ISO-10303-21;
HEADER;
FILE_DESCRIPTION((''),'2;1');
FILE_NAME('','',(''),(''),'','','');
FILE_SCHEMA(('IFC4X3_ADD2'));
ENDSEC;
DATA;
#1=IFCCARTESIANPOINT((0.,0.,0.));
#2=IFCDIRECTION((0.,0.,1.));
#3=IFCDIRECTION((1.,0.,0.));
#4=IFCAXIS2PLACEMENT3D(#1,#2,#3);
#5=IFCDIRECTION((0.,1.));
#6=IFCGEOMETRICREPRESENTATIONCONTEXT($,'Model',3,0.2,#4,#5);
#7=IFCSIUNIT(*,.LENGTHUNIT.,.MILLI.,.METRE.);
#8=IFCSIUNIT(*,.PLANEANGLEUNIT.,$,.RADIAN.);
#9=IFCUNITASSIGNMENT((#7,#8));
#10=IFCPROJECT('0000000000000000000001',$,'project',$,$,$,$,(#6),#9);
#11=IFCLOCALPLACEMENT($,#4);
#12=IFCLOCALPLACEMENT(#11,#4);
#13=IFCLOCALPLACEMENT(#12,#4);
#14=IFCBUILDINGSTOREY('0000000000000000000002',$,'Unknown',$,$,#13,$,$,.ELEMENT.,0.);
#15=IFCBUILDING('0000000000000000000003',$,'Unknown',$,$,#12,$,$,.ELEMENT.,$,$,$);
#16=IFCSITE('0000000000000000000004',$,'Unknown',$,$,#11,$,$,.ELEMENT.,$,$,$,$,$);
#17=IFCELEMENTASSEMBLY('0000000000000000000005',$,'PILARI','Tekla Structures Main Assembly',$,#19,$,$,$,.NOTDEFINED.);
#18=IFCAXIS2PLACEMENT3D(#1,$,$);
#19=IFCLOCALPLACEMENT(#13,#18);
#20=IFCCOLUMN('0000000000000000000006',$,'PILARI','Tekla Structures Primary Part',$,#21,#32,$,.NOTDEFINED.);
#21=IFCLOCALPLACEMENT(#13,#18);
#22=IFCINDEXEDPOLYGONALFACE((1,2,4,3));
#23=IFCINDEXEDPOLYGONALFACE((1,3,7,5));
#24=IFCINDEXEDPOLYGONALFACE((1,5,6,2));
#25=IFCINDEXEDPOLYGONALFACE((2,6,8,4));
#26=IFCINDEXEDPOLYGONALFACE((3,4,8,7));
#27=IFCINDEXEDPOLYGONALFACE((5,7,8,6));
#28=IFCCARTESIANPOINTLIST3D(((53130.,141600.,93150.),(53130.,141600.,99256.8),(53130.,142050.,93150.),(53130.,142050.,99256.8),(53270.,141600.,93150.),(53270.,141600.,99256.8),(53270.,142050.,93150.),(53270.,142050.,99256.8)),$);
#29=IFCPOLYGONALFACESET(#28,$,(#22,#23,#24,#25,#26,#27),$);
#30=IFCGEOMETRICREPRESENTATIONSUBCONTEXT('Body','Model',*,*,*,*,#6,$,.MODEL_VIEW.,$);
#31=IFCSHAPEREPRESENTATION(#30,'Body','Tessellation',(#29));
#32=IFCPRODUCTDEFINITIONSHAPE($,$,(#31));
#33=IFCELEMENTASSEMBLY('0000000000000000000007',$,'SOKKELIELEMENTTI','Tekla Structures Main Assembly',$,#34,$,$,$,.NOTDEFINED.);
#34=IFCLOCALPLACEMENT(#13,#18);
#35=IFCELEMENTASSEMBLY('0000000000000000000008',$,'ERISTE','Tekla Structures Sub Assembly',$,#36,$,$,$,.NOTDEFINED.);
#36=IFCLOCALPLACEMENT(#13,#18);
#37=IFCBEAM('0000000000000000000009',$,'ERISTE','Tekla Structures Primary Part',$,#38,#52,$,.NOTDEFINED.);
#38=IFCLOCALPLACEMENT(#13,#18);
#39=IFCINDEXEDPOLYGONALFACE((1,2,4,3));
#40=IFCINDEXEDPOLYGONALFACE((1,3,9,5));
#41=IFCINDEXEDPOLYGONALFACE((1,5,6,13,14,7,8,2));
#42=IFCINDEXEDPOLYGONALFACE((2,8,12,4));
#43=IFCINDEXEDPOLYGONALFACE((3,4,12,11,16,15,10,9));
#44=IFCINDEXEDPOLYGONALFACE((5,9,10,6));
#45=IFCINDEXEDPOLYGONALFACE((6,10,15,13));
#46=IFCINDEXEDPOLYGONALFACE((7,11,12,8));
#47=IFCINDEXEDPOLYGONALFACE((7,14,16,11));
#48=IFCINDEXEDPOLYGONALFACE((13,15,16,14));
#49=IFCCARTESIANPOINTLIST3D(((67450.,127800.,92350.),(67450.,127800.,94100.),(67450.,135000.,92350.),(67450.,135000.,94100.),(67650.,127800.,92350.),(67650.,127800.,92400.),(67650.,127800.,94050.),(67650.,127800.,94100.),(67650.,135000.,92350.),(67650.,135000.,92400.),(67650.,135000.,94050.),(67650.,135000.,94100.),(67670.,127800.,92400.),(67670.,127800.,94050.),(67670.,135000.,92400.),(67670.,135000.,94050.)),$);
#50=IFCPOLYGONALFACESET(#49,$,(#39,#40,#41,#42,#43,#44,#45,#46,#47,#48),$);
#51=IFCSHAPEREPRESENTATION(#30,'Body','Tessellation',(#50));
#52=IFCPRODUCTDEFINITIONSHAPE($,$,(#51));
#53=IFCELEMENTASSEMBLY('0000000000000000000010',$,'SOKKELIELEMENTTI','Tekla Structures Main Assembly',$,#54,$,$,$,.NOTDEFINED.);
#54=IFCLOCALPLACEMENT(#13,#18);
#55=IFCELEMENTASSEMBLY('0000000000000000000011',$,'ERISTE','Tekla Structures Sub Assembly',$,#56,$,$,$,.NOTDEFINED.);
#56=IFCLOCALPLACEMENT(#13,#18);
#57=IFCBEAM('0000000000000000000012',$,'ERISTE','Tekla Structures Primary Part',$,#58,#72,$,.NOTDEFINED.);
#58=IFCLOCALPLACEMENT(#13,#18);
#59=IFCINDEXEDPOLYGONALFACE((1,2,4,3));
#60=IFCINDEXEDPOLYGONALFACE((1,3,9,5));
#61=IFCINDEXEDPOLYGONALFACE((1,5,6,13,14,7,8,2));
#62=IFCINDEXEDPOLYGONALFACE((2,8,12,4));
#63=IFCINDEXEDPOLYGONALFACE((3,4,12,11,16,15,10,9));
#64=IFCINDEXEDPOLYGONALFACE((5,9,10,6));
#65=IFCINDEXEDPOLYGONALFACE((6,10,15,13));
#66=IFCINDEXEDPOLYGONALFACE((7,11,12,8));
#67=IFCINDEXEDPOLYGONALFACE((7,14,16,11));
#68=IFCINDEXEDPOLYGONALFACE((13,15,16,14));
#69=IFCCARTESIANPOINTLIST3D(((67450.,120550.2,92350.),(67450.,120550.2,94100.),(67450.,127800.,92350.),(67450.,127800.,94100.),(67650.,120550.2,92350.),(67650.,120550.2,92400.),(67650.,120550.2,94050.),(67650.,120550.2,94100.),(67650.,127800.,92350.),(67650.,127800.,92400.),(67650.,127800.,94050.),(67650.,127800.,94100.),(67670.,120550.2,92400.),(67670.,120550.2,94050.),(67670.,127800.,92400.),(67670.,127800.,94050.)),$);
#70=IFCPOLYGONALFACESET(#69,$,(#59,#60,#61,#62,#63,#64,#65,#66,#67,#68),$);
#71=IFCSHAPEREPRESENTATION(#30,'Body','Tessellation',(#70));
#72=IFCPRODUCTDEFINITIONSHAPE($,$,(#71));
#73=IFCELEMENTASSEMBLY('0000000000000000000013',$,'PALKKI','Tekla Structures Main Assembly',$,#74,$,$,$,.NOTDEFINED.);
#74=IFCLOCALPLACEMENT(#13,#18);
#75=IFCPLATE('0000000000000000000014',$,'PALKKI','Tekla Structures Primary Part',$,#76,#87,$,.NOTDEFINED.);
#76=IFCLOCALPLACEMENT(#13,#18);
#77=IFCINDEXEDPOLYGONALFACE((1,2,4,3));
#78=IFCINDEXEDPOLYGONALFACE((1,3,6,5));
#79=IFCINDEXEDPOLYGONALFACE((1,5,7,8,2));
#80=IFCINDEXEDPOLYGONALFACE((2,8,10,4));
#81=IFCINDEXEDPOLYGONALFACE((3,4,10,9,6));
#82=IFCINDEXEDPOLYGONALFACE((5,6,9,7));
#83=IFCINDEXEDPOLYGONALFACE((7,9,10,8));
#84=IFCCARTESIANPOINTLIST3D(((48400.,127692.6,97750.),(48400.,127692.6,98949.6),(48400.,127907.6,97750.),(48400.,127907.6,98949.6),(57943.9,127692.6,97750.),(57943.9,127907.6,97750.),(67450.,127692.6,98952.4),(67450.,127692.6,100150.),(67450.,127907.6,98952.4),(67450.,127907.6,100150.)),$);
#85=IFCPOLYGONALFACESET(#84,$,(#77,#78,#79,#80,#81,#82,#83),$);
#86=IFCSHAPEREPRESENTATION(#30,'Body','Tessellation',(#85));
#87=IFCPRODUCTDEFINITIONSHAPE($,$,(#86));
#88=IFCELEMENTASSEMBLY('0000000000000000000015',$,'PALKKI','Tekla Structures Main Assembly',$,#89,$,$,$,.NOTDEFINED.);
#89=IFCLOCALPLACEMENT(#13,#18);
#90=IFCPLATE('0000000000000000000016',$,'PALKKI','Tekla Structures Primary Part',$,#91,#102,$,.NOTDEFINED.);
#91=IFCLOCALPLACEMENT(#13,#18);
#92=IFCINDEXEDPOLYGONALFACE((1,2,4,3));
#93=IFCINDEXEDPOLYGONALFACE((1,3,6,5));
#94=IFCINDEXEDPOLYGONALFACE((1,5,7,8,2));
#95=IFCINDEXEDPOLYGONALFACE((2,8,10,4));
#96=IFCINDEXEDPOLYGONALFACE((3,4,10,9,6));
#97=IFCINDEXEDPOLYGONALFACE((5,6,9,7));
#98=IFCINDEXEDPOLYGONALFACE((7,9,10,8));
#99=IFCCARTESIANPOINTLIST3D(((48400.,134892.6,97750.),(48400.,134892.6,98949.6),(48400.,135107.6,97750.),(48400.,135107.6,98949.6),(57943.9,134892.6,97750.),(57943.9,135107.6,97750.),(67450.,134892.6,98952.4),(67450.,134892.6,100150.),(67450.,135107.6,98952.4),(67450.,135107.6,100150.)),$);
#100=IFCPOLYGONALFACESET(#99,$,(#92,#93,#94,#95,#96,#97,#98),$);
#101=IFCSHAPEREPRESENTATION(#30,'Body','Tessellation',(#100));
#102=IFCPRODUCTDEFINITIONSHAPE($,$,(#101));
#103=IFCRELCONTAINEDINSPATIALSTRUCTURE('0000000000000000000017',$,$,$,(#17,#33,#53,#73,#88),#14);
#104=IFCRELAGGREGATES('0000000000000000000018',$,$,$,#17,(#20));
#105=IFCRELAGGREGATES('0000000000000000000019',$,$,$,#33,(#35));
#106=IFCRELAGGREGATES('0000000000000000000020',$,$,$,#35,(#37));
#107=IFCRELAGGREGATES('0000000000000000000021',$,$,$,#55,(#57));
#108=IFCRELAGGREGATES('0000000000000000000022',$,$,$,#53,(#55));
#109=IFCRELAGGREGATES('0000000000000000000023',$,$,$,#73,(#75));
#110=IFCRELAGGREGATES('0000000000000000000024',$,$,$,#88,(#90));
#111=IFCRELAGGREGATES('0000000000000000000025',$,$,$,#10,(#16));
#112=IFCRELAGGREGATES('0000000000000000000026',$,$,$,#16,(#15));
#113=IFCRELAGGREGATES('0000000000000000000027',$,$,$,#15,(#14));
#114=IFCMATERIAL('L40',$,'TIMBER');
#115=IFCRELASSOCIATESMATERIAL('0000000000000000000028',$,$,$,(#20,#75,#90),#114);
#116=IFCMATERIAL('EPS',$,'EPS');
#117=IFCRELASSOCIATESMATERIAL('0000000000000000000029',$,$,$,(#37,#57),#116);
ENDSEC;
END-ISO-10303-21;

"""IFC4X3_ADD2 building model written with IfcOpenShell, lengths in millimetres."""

from ifc_helpers import new_model, si_unit, direction, frame, origin_with_axes, place, context, subcontext, project, spatial, line, indexed_curve, outline, extrude, material, element, aggregate, save


model = new_model("IFC4X3_ADD2")

# Units and contexts
model_context = context("Model", 3, precision=0.2, world=origin_with_axes(), true_north=direction((0.0, 1.0)))
body_context = subcontext(model_context, "Body", "Model", "MODEL_VIEW")
ifc_project = project(units=[si_unit("LENGTHUNIT", "METRE", prefix="MILLI"), si_unit("PLANEANGLEUNIT", "RADIAN")], contexts=[model_context])

# Site, building, storey
site_placement = place(None, origin_with_axes())
site = spatial("IfcSite", under=ifc_project, at=site_placement, Name="Unknown", CompositionType="ELEMENT")
building_placement = place(site_placement, origin_with_axes())
building = spatial("IfcBuilding", under=site, at=building_placement, Name="Unknown", CompositionType="ELEMENT")
storey_placement = place(building_placement, origin_with_axes())
storey = spatial("IfcBuildingStorey", under=building, at=storey_placement, Name="Unknown", CompositionType="ELEMENT", Elevation=0.0)

# Element assembly, column
ifc_material_1 = material(Name="L40", Category="TIMBER")
assembly_1_placement = place(storey_placement, frame((53200.0, 141825.0, 93150.0), z_axis=(0.0, -1.0, 0.0), x_axis=(0.0, 0.0, 1.0)))
assembly_1 = element("IfcElementAssembly", 1, at=assembly_1_placement, inside=storey, Name="PILARI", Description="Tekla Structures Main Assembly", PredefinedType="NOTDEFINED")
column_1_placement = place(assembly_1_placement, origin_with_axes())
column_1 = element("IfcColumn", 2, at=column_1_placement, material=ifc_material_1, Name="PILARI", Description="Tekla Structures Primary Part", PredefinedType="NOTDEFINED", context=body_context, shape_type="SolidModel", body=[
    extrude(outline(indexed_curve([(-225.0, -70.0), (225.0, -70.0), (225.0, 70.0), (-225.0, 70.0)], segments=[line(1, 2, 3, 4, 1)])), frame((0.0, 0.0, 0.0), z_axis=(-1.0, 0.0, 0.0), x_axis=(0.0, 0.0, 1.0)), (0.0, 0.0, -1.0), 6106.8),
])
aggregate(assembly_1, [column_1])

# Element assemblies, beams, voiding features
assembly_2_placement = place(storey_placement, frame((67390.0, 135000.0, 93150.0), z_axis=(-1.0, 0.0, 0.0), x_axis=(0.0, -1.0, 0.0)))
assembly_2 = element("IfcElementAssembly", 3, at=assembly_2_placement, inside=storey, Name="SOKKELIELEMENTTI", Description="Tekla Structures Main Assembly", PredefinedType="NOTDEFINED")
assembly_3_placement = place(assembly_2_placement, frame((0.0, 75.0, -170.0), z_axis=(0.0, 0.0, 1.0), x_axis=(1.0, 0.0, 0.0)))
assembly_3 = element("IfcElementAssembly", 4, at=assembly_3_placement, Name="ERISTE", Description="Tekla Structures Sub Assembly", PredefinedType="NOTDEFINED")
aggregate(assembly_2, [assembly_3])
ifc_material_2 = material(Name="EPS", Category="EPS")
beam_1_placement = place(assembly_3_placement, origin_with_axes())
beam_1 = element("IfcBeam", 5, at=beam_1_placement, material=ifc_material_2, Name="ERISTE", Description="Tekla Structures Primary Part", PredefinedType="NOTDEFINED", context=body_context, shape_type="SolidModel", body=[
    extrude(outline(indexed_curve([(-110.0, -875.0), (110.0, -875.0), (110.0, 875.0), (-110.0, 875.0)], segments=[line(1, 2, 3, 4, 1)])), frame((0.0, 0.0, 0.0), z_axis=(-1.0, 0.0, 0.0), x_axis=(0.0, 0.0, 1.0)), (0.0, 0.0, -1.0), 7200.0),
])
voiding_feature_1_placement = place(beam_1_placement, frame((-1.0, 850.0, -100.0), z_axis=(0.0, 0.0, 1.0), x_axis=(1.0, 0.0, 0.0)))
element("IfcVoidingFeature", 6, at=voiding_feature_1_placement, cuts=beam_1, PredefinedType="HOLE", context=body_context, shape_type="SolidModel", body=[
    extrude(outline(indexed_curve([(-10.0, -25.0), (10.0, -25.0), (10.0, 25.0), (-10.0, 25.0)], segments=[line(1, 2, 3, 4, 1)])), frame((0.0, 0.0, 0.0), z_axis=(-1.0, 0.0, 0.0), x_axis=(0.0, 0.0, 1.0)), (0.0, 0.0, -1.0), 7202.0),
])
voiding_feature_2_placement = place(beam_1_placement, frame((-1.0, -850.0, -100.0), z_axis=(0.0, 0.0, 1.0), x_axis=(1.0, 0.0, 0.0)))
element("IfcVoidingFeature", 7, at=voiding_feature_2_placement, cuts=beam_1, PredefinedType="HOLE", context=body_context, shape_type="SolidModel", body=[
    extrude(outline(indexed_curve([(-10.0, -25.0), (10.0, -25.0), (10.0, 25.0), (-10.0, 25.0)], segments=[line(1, 2, 3, 4, 1)])), frame((0.0, 0.0, 0.0), z_axis=(-1.0, 0.0, 0.0), x_axis=(0.0, 0.0, 1.0)), (0.0, 0.0, -1.0), 7202.0),
])
aggregate(assembly_3, [beam_1])
assembly_4_placement = place(storey_placement, frame((67390.0, 127800.0, 93150.0), z_axis=(-1.0, 0.0, 0.0), x_axis=(0.0, -1.0, 0.0)))
assembly_4 = element("IfcElementAssembly", 8, at=assembly_4_placement, inside=storey, Name="SOKKELIELEMENTTI", Description="Tekla Structures Main Assembly", PredefinedType="NOTDEFINED")
assembly_5_placement = place(assembly_4_placement, frame((0.0, 75.0, -170.0), z_axis=(0.0, 0.0, 1.0), x_axis=(1.0, 0.0, 0.0)))
assembly_5 = element("IfcElementAssembly", 9, at=assembly_5_placement, Name="ERISTE", Description="Tekla Structures Sub Assembly", PredefinedType="NOTDEFINED")
beam_2_placement = place(assembly_5_placement, origin_with_axes())
beam_2 = element("IfcBeam", 10, at=beam_2_placement, material=ifc_material_2, Name="ERISTE", Description="Tekla Structures Primary Part", PredefinedType="NOTDEFINED", context=body_context, shape_type="SolidModel", body=[
    extrude(outline(indexed_curve([(-110.0, -875.0), (110.0, -875.0), (110.0, 875.0), (-110.0, 875.0)], segments=[line(1, 2, 3, 4, 1)])), frame((0.0, 0.0, 0.0), z_axis=(-1.0, 0.0, 0.0), x_axis=(0.0, 0.0, 1.0)), (0.0, 0.0, -1.0), 7249.8),
])
voiding_feature_3_placement = place(beam_2_placement, frame((-1.0, 850.0, -100.0), z_axis=(0.0, 0.0, 1.0), x_axis=(1.0, 0.0, 0.0)))
element("IfcVoidingFeature", 11, at=voiding_feature_3_placement, cuts=beam_2, PredefinedType="HOLE", context=body_context, shape_type="SolidModel", body=[
    extrude(outline(indexed_curve([(-10.0, -25.0), (10.0, -25.0), (10.0, 25.0), (-10.0, 25.0)], segments=[line(1, 2, 3, 4, 1)])), frame((0.0, 0.0, 0.0), z_axis=(-1.0, 0.0, 0.0), x_axis=(0.0, 0.0, 1.0)), (0.0, 0.0, -1.0), 7251.8),
])
voiding_feature_4_placement = place(beam_2_placement, frame((-1.0, -850.0, -100.0), z_axis=(0.0, 0.0, 1.0), x_axis=(1.0, 0.0, 0.0)))
element("IfcVoidingFeature", 12, at=voiding_feature_4_placement, cuts=beam_2, PredefinedType="HOLE", context=body_context, shape_type="SolidModel", body=[
    extrude(outline(indexed_curve([(-10.0, -25.0), (10.0, -25.0), (10.0, 25.0), (-10.0, 25.0)], segments=[line(1, 2, 3, 4, 1)])), frame((0.0, 0.0, 0.0), z_axis=(-1.0, 0.0, 0.0), x_axis=(0.0, 0.0, 1.0)), (0.0, 0.0, -1.0), 7251.8),
])
aggregate(assembly_5, [beam_2])
aggregate(assembly_4, [assembly_5])

# Element assemblies, plates
assembly_6_placement = place(storey_placement, frame((67450.0, 127800.1, 100150.0), z_axis=(0.0, -1.0, 0.0), x_axis=(-0.99802, 0.0, -0.062891)))
assembly_6 = element("IfcElementAssembly", 13, at=assembly_6_placement, inside=storey, Name="PALKKI", Description="Tekla Structures Main Assembly", PredefinedType="NOTDEFINED")
plate_1_placement = place(assembly_6_placement, origin_with_axes())
plate_1 = element("IfcPlate", 14, at=plate_1_placement, material=ifc_material_1, Name="PALKKI", Description="Tekla Structures Primary Part", PredefinedType="NOTDEFINED", context=body_context, shape_type="SolidModel", body=[
    extrude(outline(indexed_curve([(0.0, 0.0), (19087.8, 0.0), (19163.2, 1197.2), (9638.2, 1797.4), (75.3, 1195.3)], segments=[line(1, 2, 3, 4, 5, 1)])), frame((0.0, 0.0, 107.5), z_axis=(0.0, 0.0, 1.0), x_axis=(1.0, 0.0, 0.0)), (0.0, 0.0, -1.0), 215.0),
])
aggregate(assembly_6, [plate_1])
assembly_7_placement = place(storey_placement, frame((67450.0, 135000.1, 100150.0), z_axis=(0.0, -1.0, 0.0), x_axis=(-0.99802, 0.0, -0.062891)))
assembly_7 = element("IfcElementAssembly", 15, at=assembly_7_placement, inside=storey, Name="PALKKI", Description="Tekla Structures Main Assembly", PredefinedType="NOTDEFINED")
plate_2_placement = place(assembly_7_placement, origin_with_axes())
plate_2 = element("IfcPlate", 16, at=plate_2_placement, material=ifc_material_1, Name="PALKKI", Description="Tekla Structures Primary Part", PredefinedType="NOTDEFINED", context=body_context, shape_type="SolidModel", body=[
    extrude(outline(indexed_curve([(0.0, 0.0), (19087.8, 0.0), (19163.2, 1197.2), (9638.2, 1797.4), (75.3, 1195.3)], segments=[line(1, 2, 3, 4, 5, 1)])), frame((0.0, 0.0, 107.5), z_axis=(0.0, 0.0, 1.0), x_axis=(1.0, 0.0, 0.0)), (0.0, 0.0, -1.0), 215.0),
])
aggregate(assembly_7, [plate_2])

save(model, "model.ifc")
